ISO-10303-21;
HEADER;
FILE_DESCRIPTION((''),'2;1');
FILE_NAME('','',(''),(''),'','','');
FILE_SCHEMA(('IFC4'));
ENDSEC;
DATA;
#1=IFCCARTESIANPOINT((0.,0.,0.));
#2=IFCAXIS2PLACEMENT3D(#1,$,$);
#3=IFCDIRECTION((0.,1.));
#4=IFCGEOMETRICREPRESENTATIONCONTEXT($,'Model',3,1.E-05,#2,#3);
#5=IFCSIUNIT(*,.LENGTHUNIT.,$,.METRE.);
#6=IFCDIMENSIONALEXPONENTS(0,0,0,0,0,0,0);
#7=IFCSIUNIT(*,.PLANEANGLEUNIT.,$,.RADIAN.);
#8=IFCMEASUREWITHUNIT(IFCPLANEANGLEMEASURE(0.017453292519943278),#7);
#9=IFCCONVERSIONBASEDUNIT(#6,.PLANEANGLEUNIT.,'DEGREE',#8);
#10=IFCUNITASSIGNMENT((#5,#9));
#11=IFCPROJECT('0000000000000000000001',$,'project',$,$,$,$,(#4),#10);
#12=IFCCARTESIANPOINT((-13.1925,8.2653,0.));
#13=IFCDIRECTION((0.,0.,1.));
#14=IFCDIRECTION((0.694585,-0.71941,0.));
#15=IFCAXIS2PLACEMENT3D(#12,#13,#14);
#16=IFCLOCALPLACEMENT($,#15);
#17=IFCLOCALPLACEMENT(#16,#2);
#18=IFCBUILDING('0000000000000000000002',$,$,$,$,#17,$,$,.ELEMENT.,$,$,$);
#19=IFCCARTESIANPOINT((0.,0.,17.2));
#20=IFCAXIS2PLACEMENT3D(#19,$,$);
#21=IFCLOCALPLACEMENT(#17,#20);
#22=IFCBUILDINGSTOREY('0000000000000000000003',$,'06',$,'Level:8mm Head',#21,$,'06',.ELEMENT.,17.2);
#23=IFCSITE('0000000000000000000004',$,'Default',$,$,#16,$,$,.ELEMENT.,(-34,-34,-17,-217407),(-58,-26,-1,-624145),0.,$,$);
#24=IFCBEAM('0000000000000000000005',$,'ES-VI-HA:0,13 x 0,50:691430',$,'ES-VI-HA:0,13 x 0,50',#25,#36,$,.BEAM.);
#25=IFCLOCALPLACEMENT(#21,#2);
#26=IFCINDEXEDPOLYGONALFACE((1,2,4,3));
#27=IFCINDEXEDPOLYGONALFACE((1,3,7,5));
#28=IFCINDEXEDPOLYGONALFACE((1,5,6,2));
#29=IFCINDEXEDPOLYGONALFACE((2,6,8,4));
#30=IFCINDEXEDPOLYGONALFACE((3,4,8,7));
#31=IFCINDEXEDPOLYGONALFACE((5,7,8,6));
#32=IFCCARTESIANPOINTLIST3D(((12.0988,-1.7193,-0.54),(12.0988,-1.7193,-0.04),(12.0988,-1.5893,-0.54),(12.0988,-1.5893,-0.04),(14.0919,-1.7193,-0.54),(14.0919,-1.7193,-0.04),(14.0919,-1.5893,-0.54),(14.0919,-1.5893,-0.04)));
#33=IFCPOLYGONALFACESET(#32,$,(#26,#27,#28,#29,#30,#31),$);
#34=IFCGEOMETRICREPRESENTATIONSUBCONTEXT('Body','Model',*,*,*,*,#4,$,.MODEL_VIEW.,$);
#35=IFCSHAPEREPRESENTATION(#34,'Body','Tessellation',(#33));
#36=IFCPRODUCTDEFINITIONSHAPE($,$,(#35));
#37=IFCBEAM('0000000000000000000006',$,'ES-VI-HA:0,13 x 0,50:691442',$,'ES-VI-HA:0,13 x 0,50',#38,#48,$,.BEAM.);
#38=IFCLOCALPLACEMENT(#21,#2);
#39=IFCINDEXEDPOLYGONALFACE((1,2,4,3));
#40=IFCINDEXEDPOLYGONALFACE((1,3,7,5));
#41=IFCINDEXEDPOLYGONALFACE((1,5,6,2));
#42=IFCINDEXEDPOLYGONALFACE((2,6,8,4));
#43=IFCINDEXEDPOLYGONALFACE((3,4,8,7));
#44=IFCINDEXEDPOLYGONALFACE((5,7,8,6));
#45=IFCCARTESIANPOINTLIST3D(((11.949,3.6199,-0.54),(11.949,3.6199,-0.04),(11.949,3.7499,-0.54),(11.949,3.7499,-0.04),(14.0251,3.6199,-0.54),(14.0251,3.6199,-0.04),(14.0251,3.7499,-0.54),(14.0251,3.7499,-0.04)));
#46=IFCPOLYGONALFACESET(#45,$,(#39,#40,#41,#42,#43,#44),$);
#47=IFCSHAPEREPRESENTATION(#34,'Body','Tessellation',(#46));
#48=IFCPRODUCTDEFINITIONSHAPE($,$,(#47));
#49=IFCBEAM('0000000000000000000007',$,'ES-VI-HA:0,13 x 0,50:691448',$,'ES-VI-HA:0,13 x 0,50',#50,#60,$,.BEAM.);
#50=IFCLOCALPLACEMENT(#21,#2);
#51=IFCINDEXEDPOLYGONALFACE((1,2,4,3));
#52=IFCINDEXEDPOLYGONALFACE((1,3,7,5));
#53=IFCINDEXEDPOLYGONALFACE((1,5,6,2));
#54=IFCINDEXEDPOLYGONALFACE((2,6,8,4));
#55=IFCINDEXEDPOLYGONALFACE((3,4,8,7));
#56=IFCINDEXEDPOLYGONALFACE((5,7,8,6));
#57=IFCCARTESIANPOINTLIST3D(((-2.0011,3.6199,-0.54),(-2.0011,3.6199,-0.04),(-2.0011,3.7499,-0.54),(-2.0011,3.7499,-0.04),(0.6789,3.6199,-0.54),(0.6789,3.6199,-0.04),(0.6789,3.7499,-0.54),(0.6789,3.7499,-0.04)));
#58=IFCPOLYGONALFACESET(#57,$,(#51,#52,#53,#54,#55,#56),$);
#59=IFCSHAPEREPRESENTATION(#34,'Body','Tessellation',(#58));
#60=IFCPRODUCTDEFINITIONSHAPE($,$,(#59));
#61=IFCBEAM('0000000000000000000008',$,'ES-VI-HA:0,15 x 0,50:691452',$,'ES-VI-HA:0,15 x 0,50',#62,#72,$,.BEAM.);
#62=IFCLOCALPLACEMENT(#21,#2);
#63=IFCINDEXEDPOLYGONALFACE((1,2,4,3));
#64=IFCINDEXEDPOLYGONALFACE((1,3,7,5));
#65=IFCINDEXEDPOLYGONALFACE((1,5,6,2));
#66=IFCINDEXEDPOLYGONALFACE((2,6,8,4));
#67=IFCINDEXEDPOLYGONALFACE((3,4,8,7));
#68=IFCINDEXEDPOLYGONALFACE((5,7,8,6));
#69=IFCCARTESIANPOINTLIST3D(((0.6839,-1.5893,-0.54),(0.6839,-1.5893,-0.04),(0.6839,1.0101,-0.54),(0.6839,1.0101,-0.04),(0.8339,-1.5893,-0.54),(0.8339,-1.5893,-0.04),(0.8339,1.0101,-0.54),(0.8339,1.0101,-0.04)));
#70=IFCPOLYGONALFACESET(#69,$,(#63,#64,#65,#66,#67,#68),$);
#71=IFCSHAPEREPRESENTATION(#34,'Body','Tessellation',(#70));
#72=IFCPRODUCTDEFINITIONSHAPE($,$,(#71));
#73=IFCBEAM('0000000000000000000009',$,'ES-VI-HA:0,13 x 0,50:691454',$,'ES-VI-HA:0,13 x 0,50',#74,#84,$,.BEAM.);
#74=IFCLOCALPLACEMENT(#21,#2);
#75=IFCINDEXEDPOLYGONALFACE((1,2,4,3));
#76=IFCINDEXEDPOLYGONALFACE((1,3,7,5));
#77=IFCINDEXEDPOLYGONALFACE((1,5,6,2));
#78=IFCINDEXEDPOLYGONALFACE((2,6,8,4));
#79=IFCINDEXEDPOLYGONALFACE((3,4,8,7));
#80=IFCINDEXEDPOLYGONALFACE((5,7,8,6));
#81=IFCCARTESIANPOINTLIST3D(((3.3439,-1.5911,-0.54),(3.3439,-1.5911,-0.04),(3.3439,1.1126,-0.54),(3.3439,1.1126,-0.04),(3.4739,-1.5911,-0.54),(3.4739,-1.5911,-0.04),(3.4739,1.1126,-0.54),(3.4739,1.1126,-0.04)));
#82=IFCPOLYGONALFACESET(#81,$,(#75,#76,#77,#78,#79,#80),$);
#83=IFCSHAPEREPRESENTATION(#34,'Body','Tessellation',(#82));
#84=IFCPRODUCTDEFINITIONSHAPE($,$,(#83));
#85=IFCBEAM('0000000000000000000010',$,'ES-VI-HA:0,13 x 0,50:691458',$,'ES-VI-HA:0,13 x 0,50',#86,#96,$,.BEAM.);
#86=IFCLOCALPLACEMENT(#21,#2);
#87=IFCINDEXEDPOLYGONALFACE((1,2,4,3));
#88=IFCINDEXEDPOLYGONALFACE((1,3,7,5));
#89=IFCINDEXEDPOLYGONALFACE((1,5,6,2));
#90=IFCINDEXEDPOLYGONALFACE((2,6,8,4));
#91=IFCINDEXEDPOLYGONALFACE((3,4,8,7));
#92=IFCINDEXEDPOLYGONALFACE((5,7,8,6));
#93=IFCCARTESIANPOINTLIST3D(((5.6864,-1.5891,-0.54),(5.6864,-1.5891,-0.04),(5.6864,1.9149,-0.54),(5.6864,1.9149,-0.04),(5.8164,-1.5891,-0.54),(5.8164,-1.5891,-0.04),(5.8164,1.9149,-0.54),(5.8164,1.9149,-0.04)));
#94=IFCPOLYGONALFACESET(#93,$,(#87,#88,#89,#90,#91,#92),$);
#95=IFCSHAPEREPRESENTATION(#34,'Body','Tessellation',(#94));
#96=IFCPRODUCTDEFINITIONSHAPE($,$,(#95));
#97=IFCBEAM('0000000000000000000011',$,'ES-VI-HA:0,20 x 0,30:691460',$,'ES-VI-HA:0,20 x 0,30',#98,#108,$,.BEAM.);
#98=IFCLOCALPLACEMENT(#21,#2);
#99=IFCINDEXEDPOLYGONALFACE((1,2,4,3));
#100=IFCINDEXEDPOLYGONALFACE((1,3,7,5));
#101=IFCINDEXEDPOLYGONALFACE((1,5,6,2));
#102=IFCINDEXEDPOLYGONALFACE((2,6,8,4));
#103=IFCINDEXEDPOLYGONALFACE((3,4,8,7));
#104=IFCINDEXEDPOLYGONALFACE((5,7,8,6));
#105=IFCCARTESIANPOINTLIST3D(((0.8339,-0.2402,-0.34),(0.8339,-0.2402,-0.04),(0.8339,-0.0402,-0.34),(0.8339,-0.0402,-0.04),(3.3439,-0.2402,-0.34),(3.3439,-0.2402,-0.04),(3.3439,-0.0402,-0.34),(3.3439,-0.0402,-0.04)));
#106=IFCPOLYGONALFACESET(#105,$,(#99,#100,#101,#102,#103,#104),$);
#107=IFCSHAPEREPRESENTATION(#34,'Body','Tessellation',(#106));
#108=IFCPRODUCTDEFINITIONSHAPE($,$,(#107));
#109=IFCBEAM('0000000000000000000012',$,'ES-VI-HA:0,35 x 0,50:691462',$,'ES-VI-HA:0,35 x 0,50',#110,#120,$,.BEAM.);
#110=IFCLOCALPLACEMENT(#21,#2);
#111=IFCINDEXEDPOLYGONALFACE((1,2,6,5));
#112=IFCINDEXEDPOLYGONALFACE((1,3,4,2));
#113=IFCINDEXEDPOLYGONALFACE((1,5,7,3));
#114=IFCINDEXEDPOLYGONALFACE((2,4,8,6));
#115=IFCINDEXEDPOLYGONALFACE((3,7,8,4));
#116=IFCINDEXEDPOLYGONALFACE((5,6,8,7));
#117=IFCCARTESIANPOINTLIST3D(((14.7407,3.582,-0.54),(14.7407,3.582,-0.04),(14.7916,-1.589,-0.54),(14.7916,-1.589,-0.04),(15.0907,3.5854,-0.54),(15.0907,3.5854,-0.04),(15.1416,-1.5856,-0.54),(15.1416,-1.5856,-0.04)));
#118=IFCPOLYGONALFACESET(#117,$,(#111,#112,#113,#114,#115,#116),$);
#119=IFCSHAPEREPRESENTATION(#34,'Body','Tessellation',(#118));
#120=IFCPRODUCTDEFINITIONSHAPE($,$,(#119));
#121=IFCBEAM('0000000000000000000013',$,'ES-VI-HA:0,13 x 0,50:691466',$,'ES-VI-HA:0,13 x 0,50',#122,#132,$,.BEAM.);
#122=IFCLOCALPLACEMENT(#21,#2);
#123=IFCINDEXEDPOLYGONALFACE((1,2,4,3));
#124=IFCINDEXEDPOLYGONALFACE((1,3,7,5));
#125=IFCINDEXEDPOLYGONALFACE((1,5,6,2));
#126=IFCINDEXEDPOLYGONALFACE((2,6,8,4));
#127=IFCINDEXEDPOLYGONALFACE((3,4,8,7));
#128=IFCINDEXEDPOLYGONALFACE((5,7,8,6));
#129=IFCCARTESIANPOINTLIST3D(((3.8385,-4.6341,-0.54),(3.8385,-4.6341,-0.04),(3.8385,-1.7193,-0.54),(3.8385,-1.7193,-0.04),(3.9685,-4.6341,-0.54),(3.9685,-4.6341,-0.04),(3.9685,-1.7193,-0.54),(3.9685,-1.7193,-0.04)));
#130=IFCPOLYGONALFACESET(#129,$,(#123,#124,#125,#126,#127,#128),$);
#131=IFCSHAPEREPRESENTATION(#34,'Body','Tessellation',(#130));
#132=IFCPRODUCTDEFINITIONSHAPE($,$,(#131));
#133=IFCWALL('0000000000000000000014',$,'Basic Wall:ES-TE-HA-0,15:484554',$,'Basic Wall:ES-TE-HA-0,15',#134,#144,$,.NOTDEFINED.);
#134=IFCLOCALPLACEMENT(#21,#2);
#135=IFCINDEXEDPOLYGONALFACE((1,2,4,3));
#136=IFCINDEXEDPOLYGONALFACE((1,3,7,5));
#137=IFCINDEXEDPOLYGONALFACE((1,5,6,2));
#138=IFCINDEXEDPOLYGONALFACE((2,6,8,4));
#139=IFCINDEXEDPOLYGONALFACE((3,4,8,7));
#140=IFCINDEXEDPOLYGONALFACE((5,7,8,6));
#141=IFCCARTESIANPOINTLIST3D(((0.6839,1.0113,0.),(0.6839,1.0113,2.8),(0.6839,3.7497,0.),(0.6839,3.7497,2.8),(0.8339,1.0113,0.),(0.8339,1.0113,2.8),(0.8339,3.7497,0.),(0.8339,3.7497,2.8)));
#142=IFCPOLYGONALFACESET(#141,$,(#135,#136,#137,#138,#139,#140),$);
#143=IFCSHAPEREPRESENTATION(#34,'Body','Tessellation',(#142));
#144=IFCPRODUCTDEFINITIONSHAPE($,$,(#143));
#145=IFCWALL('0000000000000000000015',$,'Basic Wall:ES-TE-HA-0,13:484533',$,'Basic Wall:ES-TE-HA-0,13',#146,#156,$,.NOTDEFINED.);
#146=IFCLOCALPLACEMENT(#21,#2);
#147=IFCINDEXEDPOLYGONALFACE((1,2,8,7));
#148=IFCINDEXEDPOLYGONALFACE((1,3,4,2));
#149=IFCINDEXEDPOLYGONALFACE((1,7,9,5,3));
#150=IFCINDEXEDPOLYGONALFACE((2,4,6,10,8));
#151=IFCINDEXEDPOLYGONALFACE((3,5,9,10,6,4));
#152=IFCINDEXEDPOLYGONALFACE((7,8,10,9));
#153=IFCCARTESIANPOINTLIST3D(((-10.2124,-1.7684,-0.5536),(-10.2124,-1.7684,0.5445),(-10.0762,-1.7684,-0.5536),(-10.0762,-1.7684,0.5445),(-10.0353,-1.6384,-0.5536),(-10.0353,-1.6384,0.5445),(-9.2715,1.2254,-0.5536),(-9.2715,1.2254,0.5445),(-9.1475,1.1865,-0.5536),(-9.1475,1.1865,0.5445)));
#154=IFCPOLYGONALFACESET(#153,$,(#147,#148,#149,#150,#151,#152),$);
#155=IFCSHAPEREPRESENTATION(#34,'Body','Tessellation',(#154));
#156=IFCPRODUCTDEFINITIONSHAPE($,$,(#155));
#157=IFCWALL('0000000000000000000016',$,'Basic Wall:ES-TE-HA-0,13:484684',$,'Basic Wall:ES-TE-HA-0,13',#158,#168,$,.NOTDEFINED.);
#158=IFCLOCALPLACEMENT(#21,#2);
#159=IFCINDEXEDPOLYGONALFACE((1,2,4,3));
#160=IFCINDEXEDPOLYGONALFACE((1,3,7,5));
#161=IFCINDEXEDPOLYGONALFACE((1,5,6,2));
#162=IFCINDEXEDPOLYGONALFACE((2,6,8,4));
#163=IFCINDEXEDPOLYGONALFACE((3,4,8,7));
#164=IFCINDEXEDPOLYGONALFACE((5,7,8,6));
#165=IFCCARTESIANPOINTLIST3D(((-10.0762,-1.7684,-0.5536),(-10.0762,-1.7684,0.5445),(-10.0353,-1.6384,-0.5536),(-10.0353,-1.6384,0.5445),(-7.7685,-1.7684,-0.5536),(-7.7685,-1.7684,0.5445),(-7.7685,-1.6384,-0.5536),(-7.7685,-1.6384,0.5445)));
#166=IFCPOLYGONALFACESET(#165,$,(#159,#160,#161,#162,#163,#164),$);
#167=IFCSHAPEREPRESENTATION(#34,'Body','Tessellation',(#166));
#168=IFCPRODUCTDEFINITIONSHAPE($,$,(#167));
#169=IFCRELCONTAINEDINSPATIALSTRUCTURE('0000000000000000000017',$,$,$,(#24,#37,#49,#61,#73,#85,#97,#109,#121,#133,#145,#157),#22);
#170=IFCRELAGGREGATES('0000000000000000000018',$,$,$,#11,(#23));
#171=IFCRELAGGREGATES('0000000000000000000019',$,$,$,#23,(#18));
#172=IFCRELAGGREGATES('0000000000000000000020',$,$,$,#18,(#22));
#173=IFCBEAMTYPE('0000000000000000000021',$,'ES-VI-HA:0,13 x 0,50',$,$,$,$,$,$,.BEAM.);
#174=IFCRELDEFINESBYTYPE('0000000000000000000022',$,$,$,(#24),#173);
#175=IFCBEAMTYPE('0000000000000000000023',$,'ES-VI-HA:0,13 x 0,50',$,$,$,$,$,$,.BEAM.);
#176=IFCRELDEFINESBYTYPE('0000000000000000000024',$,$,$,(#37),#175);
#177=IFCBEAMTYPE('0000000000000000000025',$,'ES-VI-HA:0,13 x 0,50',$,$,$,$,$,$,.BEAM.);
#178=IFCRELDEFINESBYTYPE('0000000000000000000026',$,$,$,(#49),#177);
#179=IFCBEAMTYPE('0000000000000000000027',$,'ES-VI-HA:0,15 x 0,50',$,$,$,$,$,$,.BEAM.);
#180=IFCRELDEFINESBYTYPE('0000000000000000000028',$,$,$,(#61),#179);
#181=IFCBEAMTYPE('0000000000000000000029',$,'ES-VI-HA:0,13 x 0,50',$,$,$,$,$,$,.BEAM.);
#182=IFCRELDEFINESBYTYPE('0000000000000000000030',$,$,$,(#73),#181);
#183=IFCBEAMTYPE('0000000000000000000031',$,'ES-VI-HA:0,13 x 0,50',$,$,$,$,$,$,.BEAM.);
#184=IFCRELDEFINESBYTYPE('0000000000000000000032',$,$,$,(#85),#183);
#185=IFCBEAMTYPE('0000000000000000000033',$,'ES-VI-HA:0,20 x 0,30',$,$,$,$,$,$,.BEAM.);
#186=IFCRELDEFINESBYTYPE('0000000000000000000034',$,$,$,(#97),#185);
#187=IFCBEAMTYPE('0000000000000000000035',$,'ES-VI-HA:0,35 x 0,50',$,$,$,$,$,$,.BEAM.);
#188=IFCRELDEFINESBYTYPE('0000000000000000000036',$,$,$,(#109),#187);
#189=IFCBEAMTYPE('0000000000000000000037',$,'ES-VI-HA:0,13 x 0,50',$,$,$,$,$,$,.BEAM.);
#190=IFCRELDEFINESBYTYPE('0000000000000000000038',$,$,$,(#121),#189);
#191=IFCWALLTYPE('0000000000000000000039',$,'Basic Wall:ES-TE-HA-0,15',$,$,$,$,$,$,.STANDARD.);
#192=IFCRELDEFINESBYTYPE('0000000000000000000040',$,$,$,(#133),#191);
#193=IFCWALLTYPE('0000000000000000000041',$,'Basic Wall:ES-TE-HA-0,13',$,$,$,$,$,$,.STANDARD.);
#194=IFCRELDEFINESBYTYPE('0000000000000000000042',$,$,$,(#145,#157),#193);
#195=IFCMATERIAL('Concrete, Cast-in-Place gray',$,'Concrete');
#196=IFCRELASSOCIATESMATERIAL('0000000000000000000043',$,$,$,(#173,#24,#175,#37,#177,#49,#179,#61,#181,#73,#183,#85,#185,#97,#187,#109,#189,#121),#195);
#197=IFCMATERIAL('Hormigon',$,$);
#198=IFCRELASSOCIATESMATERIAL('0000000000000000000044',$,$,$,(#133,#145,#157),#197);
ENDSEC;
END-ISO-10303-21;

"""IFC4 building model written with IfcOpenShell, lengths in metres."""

from ifc_helpers import new_model, entity, si_unit, converted_unit, direction, frame, origin, place, context, subcontext, project, spatial, indexed_curve, outline, extrude, source, transform, mapped, material, type_object, type_shapes, element, save


model = new_model("IFC4")

# Units and contexts
model_context = context("Model", 3, precision=1e-05, world=origin(), true_north=direction((0.0, 1.0)))
body_context = subcontext(model_context, "Body", "Model", "MODEL_VIEW")
ifc_project = project(units=[si_unit("LENGTHUNIT", "METRE"), converted_unit("PLANEANGLEUNIT", "DEGREE", entity("IfcPlaneAngleMeasure", 0.017453292519943278), si_unit("PLANEANGLEUNIT", "RADIAN"), dimensions=[0, 0, 0, 0, 0, 0, 0])], contexts=[model_context])

# Site, building, storey
site_placement = place(None, frame((-13.1925, 8.2653, 0.0), z_axis=(0.0, 0.0, 1.0), x_axis=(0.694585, -0.71941, 0.0)))
site = spatial("IfcSite", under=ifc_project, at=site_placement, Name="Default", CompositionType="ELEMENT", RefLatitude=(-34, -34, -17, -217407), RefLongitude=(-58, -26, -1, -624145), RefElevation=0.0)
building_placement = place(site_placement, origin())
building = spatial("IfcBuilding", under=site, at=building_placement, CompositionType="ELEMENT")
storey_placement = place(building_placement, frame((0.0, 0.0, 17.2)))
storey = spatial("IfcBuildingStorey", under=building, at=storey_placement, Name="06", ObjectType="Level:8mm Head", LongName="06", CompositionType="ELEMENT", Elevation=17.2)

# Beams
ifc_material_1 = material(Name="Concrete, Cast-in-Place gray", Category="Concrete")
beam_type_1 = type_object("IfcBeamType", Name="ES-VI-HA:0,13 x 0,50", PredefinedType="BEAM", material=ifc_material_1)
shared_shape_1 = source(origin(), body_context, "Body", "SweptSolid", [
    extrude(outline(indexed_curve([(-0.25, -0.065), (0.25, -0.065), (0.25, 0.065), (-0.25, 0.065), (-0.25, -0.065)], self_intersect=False)), frame((12.0988, -1.6543, 16.91), z_axis=(1.0, 0.0, 0.0), x_axis=(0.0, 0.0, -1.0)), (0.0, 0.0, 1.0), 1.9932),
])
type_shapes(beam_type_1, [shared_shape_1])
beam_1_placement = place(storey_placement, frame((0.0, 0.0, -17.2)))
element("IfcBeam", 1, at=beam_1_placement, inside=storey, type_object=beam_type_1, material=ifc_material_1, Name="ES-VI-HA:0,13 x 0,50:691430", ObjectType="ES-VI-HA:0,13 x 0,50", PredefinedType="BEAM", context=body_context, shape_type="MappedRepresentation", body=[
    mapped(shared_shape_1, transform((0.0, 0.0, 0.0), scale=1.0)),
])
beam_type_2 = type_object("IfcBeamType", Name="ES-VI-HA:0,13 x 0,50", PredefinedType="BEAM", material=ifc_material_1)
shared_shape_2 = source(origin(), body_context, "Body", "SweptSolid", [
    extrude(outline(indexed_curve([(-0.25, -0.065), (0.25, -0.065), (0.25, 0.065), (-0.25, 0.065), (-0.25, -0.065)], self_intersect=False)), frame((11.949, 3.6849, 16.91), z_axis=(1.0, 0.0, 0.0), x_axis=(0.0, 0.0, -1.0)), (0.0, 0.0, 1.0), 2.0761),
])
type_shapes(beam_type_2, [shared_shape_2])
beam_2_placement = place(storey_placement, frame((0.0, 0.0, -17.2)))
element("IfcBeam", 2, at=beam_2_placement, inside=storey, type_object=beam_type_2, material=ifc_material_1, Name="ES-VI-HA:0,13 x 0,50:691442", ObjectType="ES-VI-HA:0,13 x 0,50", PredefinedType="BEAM", context=body_context, shape_type="MappedRepresentation", body=[
    mapped(shared_shape_2, transform((0.0, 0.0, 0.0), scale=1.0)),
])
beam_type_3 = type_object("IfcBeamType", Name="ES-VI-HA:0,13 x 0,50", PredefinedType="BEAM", material=ifc_material_1)
shared_shape_3 = source(origin(), body_context, "Body", "SweptSolid", [
    extrude(outline(indexed_curve([(-0.25, -0.065), (0.25, -0.065), (0.25, 0.065), (-0.25, 0.065), (-0.25, -0.065)], self_intersect=False)), frame((-2.0011, 3.6849, 16.91), z_axis=(1.0, 0.0, 0.0), x_axis=(0.0, 0.0, -1.0)), (0.0, 0.0, 1.0), 2.68),
])
type_shapes(beam_type_3, [shared_shape_3])
beam_3_placement = place(storey_placement, frame((0.0, 0.0, -17.2)))
element("IfcBeam", 3, at=beam_3_placement, inside=storey, type_object=beam_type_3, material=ifc_material_1, Name="ES-VI-HA:0,13 x 0,50:691448", ObjectType="ES-VI-HA:0,13 x 0,50", PredefinedType="BEAM", context=body_context, shape_type="MappedRepresentation", body=[
    mapped(shared_shape_3, transform((0.0, 0.0, 0.0), scale=1.0)),
])
beam_type_4 = type_object("IfcBeamType", Name="ES-VI-HA:0,15 x 0,50", PredefinedType="BEAM", material=ifc_material_1)
shared_shape_4 = source(origin(), body_context, "Body", "SweptSolid", [
    extrude(outline(indexed_curve([(-0.075, -0.25), (0.075, -0.25), (0.075, 0.25), (-0.075, 0.25), (-0.075, -0.25)], self_intersect=False)), frame((0.7589, -1.5893, 16.91), z_axis=(0.0, 1.0, 0.0), x_axis=(-1.0, 0.0, 0.0)), (0.0, 0.0, 1.0), 2.5994),
])
type_shapes(beam_type_4, [shared_shape_4])
beam_4_placement = place(storey_placement, frame((0.0, 0.0, -17.2)))
element("IfcBeam", 4, at=beam_4_placement, inside=storey, type_object=beam_type_4, material=ifc_material_1, Name="ES-VI-HA:0,15 x 0,50:691452", ObjectType="ES-VI-HA:0,15 x 0,50", PredefinedType="BEAM", context=body_context, shape_type="MappedRepresentation", body=[
    mapped(shared_shape_4, transform((0.0, 0.0, 0.0), scale=1.0)),
])
beam_type_5 = type_object("IfcBeamType", Name="ES-VI-HA:0,13 x 0,50", PredefinedType="BEAM", material=ifc_material_1)
shared_shape_5 = source(origin(), body_context, "Body", "SweptSolid", [
    extrude(outline(indexed_curve([(-0.065, -0.25), (0.065, -0.25), (0.065, 0.25), (-0.065, 0.25), (-0.065, -0.25)], self_intersect=False)), frame((3.4089, -1.5911, 16.91), z_axis=(0.0, 1.0, 0.0), x_axis=(-1.0, 0.0, 0.0)), (0.0, 0.0, 1.0), 2.7037),
])
type_shapes(beam_type_5, [shared_shape_5])
beam_5_placement = place(storey_placement, frame((0.0, 0.0, -17.2)))
element("IfcBeam", 5, at=beam_5_placement, inside=storey, type_object=beam_type_5, material=ifc_material_1, Name="ES-VI-HA:0,13 x 0,50:691454", ObjectType="ES-VI-HA:0,13 x 0,50", PredefinedType="BEAM", context=body_context, shape_type="MappedRepresentation", body=[
    mapped(shared_shape_5, transform((0.0, 0.0, 0.0), scale=1.0)),
])
beam_type_6 = type_object("IfcBeamType", Name="ES-VI-HA:0,13 x 0,50", PredefinedType="BEAM", material=ifc_material_1)
shared_shape_6 = source(origin(), body_context, "Body", "SweptSolid", [
    extrude(outline(indexed_curve([(-0.065, -0.25), (0.065, -0.25), (0.065, 0.25), (-0.065, 0.25), (-0.065, -0.25)], self_intersect=False)), frame((5.7514, -1.5891, 16.91), z_axis=(0.0, 1.0, 0.0), x_axis=(-1.0, 0.0, 0.0)), (0.0, 0.0, 1.0), 3.5039),
])
type_shapes(beam_type_6, [shared_shape_6])
beam_6_placement = place(storey_placement, frame((0.0, 0.0, -17.2)))
element("IfcBeam", 6, at=beam_6_placement, inside=storey, type_object=beam_type_6, material=ifc_material_1, Name="ES-VI-HA:0,13 x 0,50:691458", ObjectType="ES-VI-HA:0,13 x 0,50", PredefinedType="BEAM", context=body_context, shape_type="MappedRepresentation", body=[
    mapped(shared_shape_6, transform((0.0, 0.0, 0.0), scale=1.0)),
])
beam_type_7 = type_object("IfcBeamType", Name="ES-VI-HA:0,20 x 0,30", PredefinedType="BEAM", material=ifc_material_1)
shared_shape_7 = source(origin(), body_context, "Body", "SweptSolid", [
    extrude(outline(indexed_curve([(-0.15, -0.1), (0.15, -0.1), (0.15, 0.1), (-0.15, 0.1), (-0.15, -0.1)], self_intersect=False)), frame((0.8339, -0.1402, 17.01), z_axis=(1.0, 0.0, 0.0), x_axis=(0.0, 0.0, -1.0)), (0.0, 0.0, 1.0), 2.51),
])
type_shapes(beam_type_7, [shared_shape_7])
beam_7_placement = place(storey_placement, frame((0.0, 0.0, -17.2)))
element("IfcBeam", 7, at=beam_7_placement, inside=storey, type_object=beam_type_7, material=ifc_material_1, Name="ES-VI-HA:0,20 x 0,30:691460", ObjectType="ES-VI-HA:0,20 x 0,30", PredefinedType="BEAM", context=body_context, shape_type="MappedRepresentation", body=[
    mapped(shared_shape_7, transform((0.0, 0.0, 0.0), scale=1.0)),
])
beam_type_8 = type_object("IfcBeamType", Name="ES-VI-HA:0,35 x 0,50", PredefinedType="BEAM", material=ifc_material_1)
shared_shape_8 = source(origin(), body_context, "Body", "SweptSolid", [
    extrude(outline(indexed_curve([(-0.25, -0.175), (0.25, -0.175), (0.25, 0.175), (-0.25, 0.175), (-0.25, -0.175)], self_intersect=False)), frame((14.9157, 3.5837, 16.91), z_axis=(0.009844, -0.999952, 0.0), x_axis=(0.0, 0.0, -1.0)), (0.0, 0.0, 1.0), 5.1713),
])
type_shapes(beam_type_8, [shared_shape_8])
beam_8_placement = place(storey_placement, frame((0.0, 0.0, -17.2)))
element("IfcBeam", 8, at=beam_8_placement, inside=storey, type_object=beam_type_8, material=ifc_material_1, Name="ES-VI-HA:0,35 x 0,50:691462", ObjectType="ES-VI-HA:0,35 x 0,50", PredefinedType="BEAM", context=body_context, shape_type="MappedRepresentation", body=[
    mapped(shared_shape_8, transform((0.0, 0.0, 0.0), scale=1.0)),
])
beam_type_9 = type_object("IfcBeamType", Name="ES-VI-HA:0,13 x 0,50", PredefinedType="BEAM", material=ifc_material_1)
shared_shape_9 = source(origin(), body_context, "Body", "SweptSolid", [
    extrude(outline(indexed_curve([(-0.065, -0.25), (0.065, -0.25), (0.065, 0.25), (-0.065, 0.25), (-0.065, -0.25)], self_intersect=False)), frame((3.9035, -4.6341, 16.91), z_axis=(0.0, 1.0, 0.0), x_axis=(-1.0, 0.0, 0.0)), (0.0, 0.0, 1.0), 2.9148),
])
type_shapes(beam_type_9, [shared_shape_9])
beam_9_placement = place(storey_placement, frame((0.0, 0.0, -17.2)))
element("IfcBeam", 9, at=beam_9_placement, inside=storey, type_object=beam_type_9, material=ifc_material_1, Name="ES-VI-HA:0,13 x 0,50:691466", ObjectType="ES-VI-HA:0,13 x 0,50", PredefinedType="BEAM", context=body_context, shape_type="MappedRepresentation", body=[
    mapped(shared_shape_9, transform((0.0, 0.0, 0.0), scale=1.0)),
])

# Walls
ifc_material_2 = material(Name="Hormigon")
wall_type_1 = type_object("IfcWallType", Name="Basic Wall:ES-TE-HA-0,15", PredefinedType="STANDARD")
wall_1_placement = place(storey_placement, frame((0.7589, 1.0113, 0.0), z_axis=(0.0, 0.0, 1.0), x_axis=(0.0, 1.0, 0.0)))
element("IfcWall", 10, at=wall_1_placement, inside=storey, type_object=wall_type_1, material=ifc_material_2, Name="Basic Wall:ES-TE-HA-0,15:484554", ObjectType="Basic Wall:ES-TE-HA-0,15", PredefinedType="NOTDEFINED", context=body_context, shape_type="SweptSolid", body=[
    extrude(outline(indexed_curve([(2.7384, 0.075), (0.0, 0.075), (0.0, -0.075), (2.7384, -0.075), (2.7384, 0.075)], self_intersect=False)), origin(), (0.0, 0.0, 1.0), 2.8),
])
wall_type_2 = type_object("IfcWallType", Name="Basic Wall:ES-TE-HA-0,13", PredefinedType="STANDARD")
wall_2_placement = place(storey_placement, frame((-10.1504, -1.7879, -0.5536), z_axis=(0.0, 0.0, 1.0), x_axis=(0.299835, 0.953991, 0.0)))
element("IfcWall", 11, at=wall_2_placement, inside=storey, type_object=wall_type_2, material=ifc_material_2, Name="Basic Wall:ES-TE-HA-0,13:484533", ObjectType="Basic Wall:ES-TE-HA-0,13", PredefinedType="NOTDEFINED", context=body_context, shape_type="SweptSolid", body=[
    extrude(outline(indexed_curve([(3.1382, -0.065), (3.1382, 0.065), (0.0, 0.065), (0.0409, -0.065), (0.1771, -0.065), (3.1382, -0.065)], self_intersect=False)), origin(), (0.0, 0.0, 1.0), 1.0981),
])
wall_3_placement = place(storey_placement, frame((-10.0762, -1.7034, -0.5536)))
element("IfcWall", 12, at=wall_3_placement, inside=storey, type_object=wall_type_2, material=ifc_material_2, Name="Basic Wall:ES-TE-HA-0,13:484684", ObjectType="Basic Wall:ES-TE-HA-0,13", PredefinedType="NOTDEFINED", context=body_context, shape_type="SweptSolid", body=[
    extrude(outline(indexed_curve([(2.3077, -0.065), (2.3077, 0.065), (0.0409, 0.065), (0.0, -0.065), (2.3077, -0.065)], self_intersect=False)), origin(), (0.0, 0.0, 1.0), 1.0981),
])

save(model, "model.ifc")
